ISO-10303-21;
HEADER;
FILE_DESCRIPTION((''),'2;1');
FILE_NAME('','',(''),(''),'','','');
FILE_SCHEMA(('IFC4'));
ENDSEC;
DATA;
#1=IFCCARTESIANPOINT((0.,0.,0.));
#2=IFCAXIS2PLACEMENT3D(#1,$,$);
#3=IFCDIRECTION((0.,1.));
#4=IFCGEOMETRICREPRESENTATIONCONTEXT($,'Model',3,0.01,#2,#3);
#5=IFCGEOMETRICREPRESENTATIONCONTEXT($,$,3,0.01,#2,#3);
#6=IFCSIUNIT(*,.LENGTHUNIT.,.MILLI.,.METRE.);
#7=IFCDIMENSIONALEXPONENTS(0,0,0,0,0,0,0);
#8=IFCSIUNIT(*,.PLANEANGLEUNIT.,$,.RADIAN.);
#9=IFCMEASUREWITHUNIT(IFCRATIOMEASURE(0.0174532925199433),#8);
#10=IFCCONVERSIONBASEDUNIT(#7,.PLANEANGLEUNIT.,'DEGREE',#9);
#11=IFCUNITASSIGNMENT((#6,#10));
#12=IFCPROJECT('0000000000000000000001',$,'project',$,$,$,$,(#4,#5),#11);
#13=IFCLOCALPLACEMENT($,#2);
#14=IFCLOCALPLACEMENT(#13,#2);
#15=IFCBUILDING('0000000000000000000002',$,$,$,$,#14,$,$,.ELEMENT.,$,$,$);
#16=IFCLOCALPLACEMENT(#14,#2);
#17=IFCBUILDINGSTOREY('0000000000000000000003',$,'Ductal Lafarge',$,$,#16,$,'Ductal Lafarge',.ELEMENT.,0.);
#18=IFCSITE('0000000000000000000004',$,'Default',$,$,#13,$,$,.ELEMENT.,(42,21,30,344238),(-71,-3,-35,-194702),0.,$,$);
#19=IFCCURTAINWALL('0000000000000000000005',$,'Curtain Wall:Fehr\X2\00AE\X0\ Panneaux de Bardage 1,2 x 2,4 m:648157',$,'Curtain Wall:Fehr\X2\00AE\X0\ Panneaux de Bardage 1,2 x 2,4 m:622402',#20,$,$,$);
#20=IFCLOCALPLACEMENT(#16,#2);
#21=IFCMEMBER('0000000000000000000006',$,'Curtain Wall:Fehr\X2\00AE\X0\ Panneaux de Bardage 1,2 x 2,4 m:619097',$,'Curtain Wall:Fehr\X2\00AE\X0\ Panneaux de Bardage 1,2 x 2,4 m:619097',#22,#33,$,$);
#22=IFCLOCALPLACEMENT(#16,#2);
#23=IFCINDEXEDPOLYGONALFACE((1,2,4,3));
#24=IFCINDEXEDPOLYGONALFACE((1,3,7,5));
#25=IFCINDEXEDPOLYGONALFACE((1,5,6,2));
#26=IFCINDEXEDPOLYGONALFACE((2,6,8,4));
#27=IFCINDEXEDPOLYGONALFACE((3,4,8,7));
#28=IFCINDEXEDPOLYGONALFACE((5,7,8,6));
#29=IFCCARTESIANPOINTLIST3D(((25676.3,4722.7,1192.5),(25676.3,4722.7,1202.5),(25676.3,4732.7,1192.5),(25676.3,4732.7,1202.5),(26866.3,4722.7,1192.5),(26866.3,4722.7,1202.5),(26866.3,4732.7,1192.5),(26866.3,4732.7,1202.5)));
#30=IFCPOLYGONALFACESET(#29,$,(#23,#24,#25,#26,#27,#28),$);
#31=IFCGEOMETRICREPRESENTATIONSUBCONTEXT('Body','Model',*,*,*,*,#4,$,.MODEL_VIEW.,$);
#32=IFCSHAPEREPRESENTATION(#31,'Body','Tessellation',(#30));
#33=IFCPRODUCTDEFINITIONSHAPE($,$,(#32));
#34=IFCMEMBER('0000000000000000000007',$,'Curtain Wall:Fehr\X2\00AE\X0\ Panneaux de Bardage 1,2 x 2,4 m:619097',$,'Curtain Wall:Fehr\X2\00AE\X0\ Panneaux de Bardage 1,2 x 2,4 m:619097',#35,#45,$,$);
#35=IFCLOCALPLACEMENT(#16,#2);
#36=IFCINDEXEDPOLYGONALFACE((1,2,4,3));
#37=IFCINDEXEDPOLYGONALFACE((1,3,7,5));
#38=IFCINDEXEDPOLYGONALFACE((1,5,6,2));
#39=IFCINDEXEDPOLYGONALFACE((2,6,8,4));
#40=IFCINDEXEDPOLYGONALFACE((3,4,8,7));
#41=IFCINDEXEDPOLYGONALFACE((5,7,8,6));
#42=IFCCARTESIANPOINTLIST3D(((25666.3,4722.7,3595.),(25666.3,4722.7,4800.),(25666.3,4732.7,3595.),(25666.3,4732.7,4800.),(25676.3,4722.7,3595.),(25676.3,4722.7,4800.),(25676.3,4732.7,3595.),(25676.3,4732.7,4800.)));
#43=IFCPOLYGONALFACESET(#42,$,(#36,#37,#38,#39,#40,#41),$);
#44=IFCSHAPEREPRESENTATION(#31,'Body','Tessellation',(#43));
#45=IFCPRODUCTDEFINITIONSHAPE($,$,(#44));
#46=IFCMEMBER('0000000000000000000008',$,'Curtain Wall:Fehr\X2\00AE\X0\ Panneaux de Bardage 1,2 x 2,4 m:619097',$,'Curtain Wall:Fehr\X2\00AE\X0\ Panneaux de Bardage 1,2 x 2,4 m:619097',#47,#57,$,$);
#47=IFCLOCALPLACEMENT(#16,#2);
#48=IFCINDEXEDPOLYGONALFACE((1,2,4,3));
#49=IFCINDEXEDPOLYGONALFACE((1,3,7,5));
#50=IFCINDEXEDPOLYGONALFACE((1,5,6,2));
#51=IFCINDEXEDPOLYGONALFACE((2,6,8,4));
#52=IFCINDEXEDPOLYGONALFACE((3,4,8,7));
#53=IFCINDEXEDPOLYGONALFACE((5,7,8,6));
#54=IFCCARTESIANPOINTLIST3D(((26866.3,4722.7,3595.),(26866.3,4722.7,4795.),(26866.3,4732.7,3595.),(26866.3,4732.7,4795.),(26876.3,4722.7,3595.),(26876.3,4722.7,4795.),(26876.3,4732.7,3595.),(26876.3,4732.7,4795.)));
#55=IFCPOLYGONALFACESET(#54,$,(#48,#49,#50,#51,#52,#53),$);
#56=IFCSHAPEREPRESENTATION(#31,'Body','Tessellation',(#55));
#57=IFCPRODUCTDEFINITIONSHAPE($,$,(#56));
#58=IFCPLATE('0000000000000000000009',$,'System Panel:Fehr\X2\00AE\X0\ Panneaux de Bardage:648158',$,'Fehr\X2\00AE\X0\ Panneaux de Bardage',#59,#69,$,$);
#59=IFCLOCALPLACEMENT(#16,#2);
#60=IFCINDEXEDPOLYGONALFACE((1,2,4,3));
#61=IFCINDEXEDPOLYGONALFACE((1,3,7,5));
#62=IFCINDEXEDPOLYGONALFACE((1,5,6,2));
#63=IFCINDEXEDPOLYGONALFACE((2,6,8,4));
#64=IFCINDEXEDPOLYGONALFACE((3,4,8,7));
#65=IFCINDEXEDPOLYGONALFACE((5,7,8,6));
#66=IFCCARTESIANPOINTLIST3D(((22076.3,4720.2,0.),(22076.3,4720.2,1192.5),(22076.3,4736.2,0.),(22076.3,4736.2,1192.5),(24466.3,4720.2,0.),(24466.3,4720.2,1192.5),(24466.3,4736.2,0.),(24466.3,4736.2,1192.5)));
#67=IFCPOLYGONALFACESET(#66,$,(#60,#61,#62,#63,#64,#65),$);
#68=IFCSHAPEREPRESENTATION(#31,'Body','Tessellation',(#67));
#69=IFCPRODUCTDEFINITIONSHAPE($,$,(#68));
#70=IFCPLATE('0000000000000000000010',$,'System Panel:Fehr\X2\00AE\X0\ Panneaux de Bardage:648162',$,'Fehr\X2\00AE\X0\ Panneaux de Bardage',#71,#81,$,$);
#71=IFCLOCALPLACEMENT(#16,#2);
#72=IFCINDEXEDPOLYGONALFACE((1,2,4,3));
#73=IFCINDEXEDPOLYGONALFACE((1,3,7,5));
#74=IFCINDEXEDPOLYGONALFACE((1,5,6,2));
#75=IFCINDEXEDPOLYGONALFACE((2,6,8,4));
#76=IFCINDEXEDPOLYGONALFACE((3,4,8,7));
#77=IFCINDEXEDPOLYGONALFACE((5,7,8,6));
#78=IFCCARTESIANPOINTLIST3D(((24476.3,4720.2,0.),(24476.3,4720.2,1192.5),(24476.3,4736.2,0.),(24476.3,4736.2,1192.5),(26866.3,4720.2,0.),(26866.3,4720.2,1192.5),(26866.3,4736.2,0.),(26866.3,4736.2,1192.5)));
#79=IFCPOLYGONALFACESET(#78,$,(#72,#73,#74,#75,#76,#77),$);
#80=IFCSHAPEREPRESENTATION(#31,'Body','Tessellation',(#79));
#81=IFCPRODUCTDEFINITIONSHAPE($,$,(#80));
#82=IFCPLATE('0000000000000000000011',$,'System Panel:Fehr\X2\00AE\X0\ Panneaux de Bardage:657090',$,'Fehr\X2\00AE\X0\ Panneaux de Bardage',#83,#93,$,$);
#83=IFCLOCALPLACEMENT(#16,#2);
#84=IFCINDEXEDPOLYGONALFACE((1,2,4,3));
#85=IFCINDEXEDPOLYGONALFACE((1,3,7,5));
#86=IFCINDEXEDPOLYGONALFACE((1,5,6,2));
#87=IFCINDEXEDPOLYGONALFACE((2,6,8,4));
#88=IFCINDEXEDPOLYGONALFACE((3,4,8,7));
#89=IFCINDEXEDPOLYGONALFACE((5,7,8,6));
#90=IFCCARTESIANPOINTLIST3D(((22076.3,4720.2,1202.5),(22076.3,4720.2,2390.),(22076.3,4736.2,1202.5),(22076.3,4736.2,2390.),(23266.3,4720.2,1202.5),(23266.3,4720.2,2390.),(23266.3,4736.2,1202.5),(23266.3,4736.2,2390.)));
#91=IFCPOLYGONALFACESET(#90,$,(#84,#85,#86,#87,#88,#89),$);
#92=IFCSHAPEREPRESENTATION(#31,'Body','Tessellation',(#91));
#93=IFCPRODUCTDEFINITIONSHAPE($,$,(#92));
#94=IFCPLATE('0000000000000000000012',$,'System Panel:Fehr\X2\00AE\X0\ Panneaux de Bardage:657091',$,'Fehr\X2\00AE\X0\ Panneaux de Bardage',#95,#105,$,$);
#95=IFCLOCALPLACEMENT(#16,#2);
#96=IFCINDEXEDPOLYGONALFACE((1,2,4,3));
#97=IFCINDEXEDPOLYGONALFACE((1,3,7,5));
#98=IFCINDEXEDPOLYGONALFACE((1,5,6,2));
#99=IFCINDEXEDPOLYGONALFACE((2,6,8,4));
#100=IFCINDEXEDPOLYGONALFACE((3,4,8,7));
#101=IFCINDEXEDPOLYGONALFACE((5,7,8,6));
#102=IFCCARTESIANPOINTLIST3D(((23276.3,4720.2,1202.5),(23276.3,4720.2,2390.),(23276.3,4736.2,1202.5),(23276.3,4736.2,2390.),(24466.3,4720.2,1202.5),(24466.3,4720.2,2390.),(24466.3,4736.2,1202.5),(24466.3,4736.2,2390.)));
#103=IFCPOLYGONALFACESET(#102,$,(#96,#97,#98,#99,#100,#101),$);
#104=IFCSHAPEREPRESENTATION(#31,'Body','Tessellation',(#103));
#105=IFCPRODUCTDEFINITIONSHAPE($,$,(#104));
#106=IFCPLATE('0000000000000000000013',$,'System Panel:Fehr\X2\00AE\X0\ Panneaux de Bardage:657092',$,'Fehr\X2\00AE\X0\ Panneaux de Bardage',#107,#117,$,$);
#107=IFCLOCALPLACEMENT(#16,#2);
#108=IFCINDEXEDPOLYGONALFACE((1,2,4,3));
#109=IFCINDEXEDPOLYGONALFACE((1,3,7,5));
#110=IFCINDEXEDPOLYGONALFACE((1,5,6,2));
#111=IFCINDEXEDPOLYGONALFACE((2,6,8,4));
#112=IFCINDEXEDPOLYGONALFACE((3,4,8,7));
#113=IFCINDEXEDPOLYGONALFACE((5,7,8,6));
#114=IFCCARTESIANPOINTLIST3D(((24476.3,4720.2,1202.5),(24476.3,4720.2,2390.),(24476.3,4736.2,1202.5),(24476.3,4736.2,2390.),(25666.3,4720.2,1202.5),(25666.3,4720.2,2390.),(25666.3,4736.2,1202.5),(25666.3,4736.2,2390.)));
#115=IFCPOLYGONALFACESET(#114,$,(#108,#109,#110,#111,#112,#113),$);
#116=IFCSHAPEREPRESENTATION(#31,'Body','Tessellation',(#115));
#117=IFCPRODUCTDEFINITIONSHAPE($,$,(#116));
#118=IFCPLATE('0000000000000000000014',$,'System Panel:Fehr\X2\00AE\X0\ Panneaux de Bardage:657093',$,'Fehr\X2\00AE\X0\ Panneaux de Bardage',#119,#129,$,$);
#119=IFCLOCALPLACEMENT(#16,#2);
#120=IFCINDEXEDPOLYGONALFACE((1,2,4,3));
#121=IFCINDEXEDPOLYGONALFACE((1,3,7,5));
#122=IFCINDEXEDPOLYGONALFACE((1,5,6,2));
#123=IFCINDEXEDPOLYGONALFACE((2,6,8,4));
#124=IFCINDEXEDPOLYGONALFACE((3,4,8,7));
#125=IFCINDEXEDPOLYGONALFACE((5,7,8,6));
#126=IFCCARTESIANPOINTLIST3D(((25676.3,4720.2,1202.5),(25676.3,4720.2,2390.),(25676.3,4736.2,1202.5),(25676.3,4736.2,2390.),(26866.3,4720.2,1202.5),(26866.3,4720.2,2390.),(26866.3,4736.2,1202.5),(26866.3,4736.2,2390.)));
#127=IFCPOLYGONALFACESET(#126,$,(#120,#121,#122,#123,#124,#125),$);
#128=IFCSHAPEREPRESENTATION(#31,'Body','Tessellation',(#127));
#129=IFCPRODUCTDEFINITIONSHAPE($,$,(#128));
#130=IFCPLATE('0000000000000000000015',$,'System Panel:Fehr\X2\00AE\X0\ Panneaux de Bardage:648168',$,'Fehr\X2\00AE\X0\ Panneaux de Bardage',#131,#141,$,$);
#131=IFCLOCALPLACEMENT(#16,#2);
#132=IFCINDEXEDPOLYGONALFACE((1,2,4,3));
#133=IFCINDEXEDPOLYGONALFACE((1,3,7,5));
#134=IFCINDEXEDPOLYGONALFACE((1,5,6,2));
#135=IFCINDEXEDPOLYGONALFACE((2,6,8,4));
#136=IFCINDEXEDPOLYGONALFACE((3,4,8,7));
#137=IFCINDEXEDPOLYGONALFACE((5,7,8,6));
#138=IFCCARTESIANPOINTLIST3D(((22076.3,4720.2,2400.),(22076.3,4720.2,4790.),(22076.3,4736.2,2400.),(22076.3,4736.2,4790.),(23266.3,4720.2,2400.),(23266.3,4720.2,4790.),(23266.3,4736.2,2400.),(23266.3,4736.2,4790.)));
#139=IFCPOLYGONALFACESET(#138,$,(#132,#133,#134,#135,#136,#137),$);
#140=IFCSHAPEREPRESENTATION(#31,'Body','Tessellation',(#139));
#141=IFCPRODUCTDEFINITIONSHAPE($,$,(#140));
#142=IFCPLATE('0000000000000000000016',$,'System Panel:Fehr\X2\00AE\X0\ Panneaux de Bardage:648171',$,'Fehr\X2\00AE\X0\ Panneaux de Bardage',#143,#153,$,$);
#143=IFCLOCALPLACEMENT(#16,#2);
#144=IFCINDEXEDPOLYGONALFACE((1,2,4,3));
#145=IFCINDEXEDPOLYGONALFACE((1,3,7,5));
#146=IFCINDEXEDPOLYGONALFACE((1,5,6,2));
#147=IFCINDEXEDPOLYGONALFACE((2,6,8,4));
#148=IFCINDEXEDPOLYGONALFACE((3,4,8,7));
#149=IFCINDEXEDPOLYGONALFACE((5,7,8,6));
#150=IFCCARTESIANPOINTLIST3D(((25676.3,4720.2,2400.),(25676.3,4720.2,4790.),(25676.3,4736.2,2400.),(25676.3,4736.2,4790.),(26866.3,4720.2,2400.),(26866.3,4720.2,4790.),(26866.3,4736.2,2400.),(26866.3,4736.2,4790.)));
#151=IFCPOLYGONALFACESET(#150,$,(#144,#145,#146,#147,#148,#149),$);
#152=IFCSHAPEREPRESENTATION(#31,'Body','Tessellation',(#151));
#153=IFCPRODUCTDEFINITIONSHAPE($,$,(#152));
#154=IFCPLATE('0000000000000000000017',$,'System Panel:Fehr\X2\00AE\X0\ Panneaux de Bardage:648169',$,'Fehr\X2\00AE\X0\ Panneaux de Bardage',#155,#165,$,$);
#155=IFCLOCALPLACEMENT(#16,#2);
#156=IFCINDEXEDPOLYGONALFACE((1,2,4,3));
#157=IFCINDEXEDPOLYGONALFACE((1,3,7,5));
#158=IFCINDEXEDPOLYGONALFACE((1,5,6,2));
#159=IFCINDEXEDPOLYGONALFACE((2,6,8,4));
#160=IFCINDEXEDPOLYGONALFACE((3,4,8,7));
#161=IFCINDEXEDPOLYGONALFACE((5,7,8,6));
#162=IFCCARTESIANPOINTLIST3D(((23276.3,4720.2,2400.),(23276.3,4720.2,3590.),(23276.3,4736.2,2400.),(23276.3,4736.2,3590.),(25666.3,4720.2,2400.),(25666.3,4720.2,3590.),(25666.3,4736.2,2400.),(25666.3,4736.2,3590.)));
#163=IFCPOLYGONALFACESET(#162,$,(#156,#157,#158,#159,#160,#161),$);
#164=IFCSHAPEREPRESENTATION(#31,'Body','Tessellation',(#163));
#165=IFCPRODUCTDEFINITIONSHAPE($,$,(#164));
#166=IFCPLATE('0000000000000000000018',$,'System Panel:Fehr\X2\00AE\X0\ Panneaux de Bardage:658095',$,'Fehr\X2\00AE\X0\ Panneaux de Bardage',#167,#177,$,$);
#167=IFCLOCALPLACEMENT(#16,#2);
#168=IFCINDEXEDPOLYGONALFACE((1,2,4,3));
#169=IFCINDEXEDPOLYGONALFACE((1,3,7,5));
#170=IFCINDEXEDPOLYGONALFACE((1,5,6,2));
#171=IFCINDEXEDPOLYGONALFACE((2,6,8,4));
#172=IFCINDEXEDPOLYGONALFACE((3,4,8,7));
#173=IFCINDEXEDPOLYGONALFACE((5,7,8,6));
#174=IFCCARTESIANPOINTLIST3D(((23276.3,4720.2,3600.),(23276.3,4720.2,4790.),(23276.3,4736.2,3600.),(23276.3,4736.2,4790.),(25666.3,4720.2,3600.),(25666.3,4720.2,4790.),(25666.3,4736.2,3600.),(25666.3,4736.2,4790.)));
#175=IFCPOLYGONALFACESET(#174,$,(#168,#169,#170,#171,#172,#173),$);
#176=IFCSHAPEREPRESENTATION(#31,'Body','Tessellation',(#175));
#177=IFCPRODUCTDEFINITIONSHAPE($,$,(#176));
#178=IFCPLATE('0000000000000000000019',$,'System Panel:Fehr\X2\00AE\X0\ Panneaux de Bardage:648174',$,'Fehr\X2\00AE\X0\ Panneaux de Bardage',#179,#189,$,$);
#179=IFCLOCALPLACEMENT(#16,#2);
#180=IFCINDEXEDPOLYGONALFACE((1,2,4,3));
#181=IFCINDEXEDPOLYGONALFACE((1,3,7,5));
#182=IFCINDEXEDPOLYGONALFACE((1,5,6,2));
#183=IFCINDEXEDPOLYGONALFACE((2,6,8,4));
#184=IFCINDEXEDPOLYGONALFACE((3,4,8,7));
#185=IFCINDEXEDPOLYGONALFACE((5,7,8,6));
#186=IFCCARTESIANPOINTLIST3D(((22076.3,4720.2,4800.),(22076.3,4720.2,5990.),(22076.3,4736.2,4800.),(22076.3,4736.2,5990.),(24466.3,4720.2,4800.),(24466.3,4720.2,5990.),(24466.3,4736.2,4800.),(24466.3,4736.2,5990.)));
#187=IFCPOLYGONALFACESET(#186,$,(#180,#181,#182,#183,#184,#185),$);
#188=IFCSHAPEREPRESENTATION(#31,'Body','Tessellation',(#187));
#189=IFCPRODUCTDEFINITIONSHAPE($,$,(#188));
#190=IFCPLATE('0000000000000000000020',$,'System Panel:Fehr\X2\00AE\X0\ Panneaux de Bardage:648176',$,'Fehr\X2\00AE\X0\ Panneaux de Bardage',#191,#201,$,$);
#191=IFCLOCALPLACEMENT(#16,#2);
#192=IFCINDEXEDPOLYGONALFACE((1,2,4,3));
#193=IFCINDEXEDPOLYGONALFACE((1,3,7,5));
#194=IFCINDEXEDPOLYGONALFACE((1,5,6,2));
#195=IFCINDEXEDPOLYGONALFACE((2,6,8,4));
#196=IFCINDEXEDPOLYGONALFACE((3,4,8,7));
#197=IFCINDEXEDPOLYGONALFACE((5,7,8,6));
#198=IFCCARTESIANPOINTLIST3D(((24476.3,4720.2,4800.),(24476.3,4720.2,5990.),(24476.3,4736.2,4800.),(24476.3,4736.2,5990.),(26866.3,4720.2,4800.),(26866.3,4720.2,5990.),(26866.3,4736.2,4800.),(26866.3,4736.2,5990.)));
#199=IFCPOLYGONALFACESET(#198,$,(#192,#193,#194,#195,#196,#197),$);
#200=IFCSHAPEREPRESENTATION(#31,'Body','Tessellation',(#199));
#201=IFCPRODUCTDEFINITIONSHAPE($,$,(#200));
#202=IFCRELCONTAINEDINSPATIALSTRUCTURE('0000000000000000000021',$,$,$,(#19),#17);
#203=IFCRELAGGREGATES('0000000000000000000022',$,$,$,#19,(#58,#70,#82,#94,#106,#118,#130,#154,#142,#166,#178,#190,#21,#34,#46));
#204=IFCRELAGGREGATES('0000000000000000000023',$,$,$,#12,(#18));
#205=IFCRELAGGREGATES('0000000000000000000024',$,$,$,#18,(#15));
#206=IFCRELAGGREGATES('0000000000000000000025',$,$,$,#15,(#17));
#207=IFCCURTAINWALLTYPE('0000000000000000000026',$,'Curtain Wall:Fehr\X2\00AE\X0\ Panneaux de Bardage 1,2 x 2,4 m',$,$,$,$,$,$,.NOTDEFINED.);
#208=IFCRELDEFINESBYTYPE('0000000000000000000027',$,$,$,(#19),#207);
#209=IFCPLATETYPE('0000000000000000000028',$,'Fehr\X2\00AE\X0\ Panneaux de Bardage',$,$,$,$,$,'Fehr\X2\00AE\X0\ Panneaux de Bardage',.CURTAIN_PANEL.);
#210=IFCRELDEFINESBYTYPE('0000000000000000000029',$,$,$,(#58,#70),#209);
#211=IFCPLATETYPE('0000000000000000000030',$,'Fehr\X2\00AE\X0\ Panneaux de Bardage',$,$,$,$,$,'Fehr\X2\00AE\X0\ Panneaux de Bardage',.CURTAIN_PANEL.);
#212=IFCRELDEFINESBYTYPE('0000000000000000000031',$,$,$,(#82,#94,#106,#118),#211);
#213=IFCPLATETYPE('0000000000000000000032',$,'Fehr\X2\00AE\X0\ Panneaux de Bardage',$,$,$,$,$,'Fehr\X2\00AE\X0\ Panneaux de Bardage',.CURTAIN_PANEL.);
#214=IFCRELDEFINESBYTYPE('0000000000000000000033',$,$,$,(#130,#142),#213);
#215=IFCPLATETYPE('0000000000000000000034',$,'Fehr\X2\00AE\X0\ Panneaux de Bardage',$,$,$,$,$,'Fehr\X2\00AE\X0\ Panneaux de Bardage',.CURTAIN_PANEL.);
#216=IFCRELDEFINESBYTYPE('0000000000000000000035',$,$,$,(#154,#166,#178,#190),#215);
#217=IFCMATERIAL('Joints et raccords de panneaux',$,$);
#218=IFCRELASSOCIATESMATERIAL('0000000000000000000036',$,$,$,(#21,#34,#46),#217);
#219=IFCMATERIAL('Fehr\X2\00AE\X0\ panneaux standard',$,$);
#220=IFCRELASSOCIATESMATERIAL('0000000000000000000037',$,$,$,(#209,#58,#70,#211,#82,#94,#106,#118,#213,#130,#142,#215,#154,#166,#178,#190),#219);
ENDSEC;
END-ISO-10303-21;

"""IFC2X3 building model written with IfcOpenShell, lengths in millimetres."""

from ifc_helpers import new_model, entity, si_unit, converted_unit, direction, frame, frame_2d, origin, origin_2d_with_axis, place, context, subcontext, project, spatial, rectangle, extrude, source, transform, mapped, material, type_object, type_shapes, element, aggregate, save


model = new_model("IFC2X3")

# Units and contexts
model_context = context("Model", 3, precision=0.01, world=origin(), true_north=direction((0.0, 1.0)))
context_of_model = context(None, 3, precision=0.01, world=origin(), true_north=direction((0.0, 1.0)))
body_context = subcontext(model_context, "Body", "Model", "MODEL_VIEW")
ifc_project = project(units=[si_unit("LENGTHUNIT", "METRE", prefix="MILLI"), converted_unit("PLANEANGLEUNIT", "DEGREE", entity("IfcRatioMeasure", 0.0174532925199433), si_unit("PLANEANGLEUNIT", "RADIAN"), dimensions=[0, 0, 0, 0, 0, 0, 0])], contexts=[model_context, context_of_model])

# Site, building, storey
site_placement = place(None, origin())
site = spatial("IfcSite", under=ifc_project, at=site_placement, Name="Default", CompositionType="ELEMENT", RefLatitude=(42, 21, 30, 344238), RefLongitude=(-71, -3, -35, -194702), RefElevation=0.0)
building_placement = place(site_placement, origin())
building = spatial("IfcBuilding", under=site, at=building_placement, CompositionType="ELEMENT")
storey_placement = place(building_placement, origin())
storey = spatial("IfcBuildingStorey", under=building, at=storey_placement, Name="Ductal Lafarge", LongName="Ductal Lafarge", CompositionType="ELEMENT", Elevation=0.0)

# Curtain wall, members, plates
curtain_wall_type = type_object("IfcCurtainWallType", Name="Curtain Wall:Fehr® Panneaux de Bardage 1,2 x 2,4 m", PredefinedType="NOTDEFINED")
curtain_wall_placement = place(storey_placement, origin())
curtain_wall = element("IfcCurtainWall", 1, at=curtain_wall_placement, inside=storey, type_object=curtain_wall_type, Name="Curtain Wall:Fehr® Panneaux de Bardage 1,2 x 2,4 m:648157", ObjectType="Curtain Wall:Fehr® Panneaux de Bardage 1,2 x 2,4 m:622402")
ifc_material_1 = material(Name="Joints et raccords de panneaux")
member_1_placement = place(curtain_wall_placement, frame((25676.3, 4722.7, 1192.5)))
member_1 = element("IfcMember", 2, at=member_1_placement, material=ifc_material_1, Name="Curtain Wall:Fehr® Panneaux de Bardage 1,2 x 2,4 m:619097", ObjectType="Curtain Wall:Fehr® Panneaux de Bardage 1,2 x 2,4 m:619097", context=body_context, shape_type="SweptSolid", body=[
    extrude(rectangle(XDim=1190.0, YDim=10.0, at=frame_2d((0.0, 0.0), x_axis=(1.0, 0.0))), frame((595.0, 5.0, 0.0), z_axis=(0.0, 0.0, 1.0), x_axis=(-1.0, 0.0, 0.0)), (0.0, 0.0, 1.0), 10.0),
])
member_2_placement = place(curtain_wall_placement, frame((25666.3, 4722.7, 3595.0)))
member_2 = element("IfcMember", 3, at=member_2_placement, material=ifc_material_1, Name="Curtain Wall:Fehr® Panneaux de Bardage 1,2 x 2,4 m:619097", ObjectType="Curtain Wall:Fehr® Panneaux de Bardage 1,2 x 2,4 m:619097", context=body_context, shape_type="SweptSolid", body=[
    extrude(rectangle(XDim=10.0, YDim=10.0, at=origin_2d_with_axis()), frame((5.0, 5.0, 0.0), z_axis=(0.0, 0.0, 1.0), x_axis=(0.0, 1.0, 0.0)), (0.0, 0.0, 1.0), 1205.0),
])
member_3_placement = place(curtain_wall_placement, frame((26866.3, 4722.7, 3595.0)))
member_3 = element("IfcMember", 4, at=member_3_placement, material=ifc_material_1, Name="Curtain Wall:Fehr® Panneaux de Bardage 1,2 x 2,4 m:619097", ObjectType="Curtain Wall:Fehr® Panneaux de Bardage 1,2 x 2,4 m:619097", context=body_context, shape_type="SweptSolid", body=[
    extrude(rectangle(XDim=10.0, YDim=10.0, at=frame_2d((0.0, 0.0), x_axis=(1.0, 0.0))), frame((5.0, 5.0, 0.0), z_axis=(0.0, 0.0, 1.0), x_axis=(0.0, 1.0, 0.0)), (0.0, 0.0, 1.0), 1200.0),
])
ifc_material_2 = material(Name="Fehr® panneaux standard")
plate_type_1 = type_object("IfcPlateType", Name="Fehr® Panneaux de Bardage", ElementType="Fehr® Panneaux de Bardage", PredefinedType="CURTAIN_PANEL", material=ifc_material_2)
shared_shape_1 = source(origin(), body_context, "Body", "SweptSolid", [
    extrude(rectangle(XDim=1192.5, YDim=2390.0, at=frame_2d((0.0, 0.0), x_axis=(1.0, 0.0))), frame((0.0, -8.0, 596.2), z_axis=(0.0, 1.0, 0.0), x_axis=(0.0, 0.0, 1.0)), (0.0, 0.0, 1.0), 16.0),
])
type_shapes(plate_type_1, [shared_shape_1])
plate_1_placement = place(curtain_wall_placement, frame((23271.3, 4728.2, 0.0)))
plate_1 = element("IfcPlate", 5, at=plate_1_placement, type_object=plate_type_1, material=ifc_material_2, Name="System Panel:Fehr® Panneaux de Bardage:648158", ObjectType="Fehr® Panneaux de Bardage", context=body_context, shape_type="MappedRepresentation", body=[
    mapped(shared_shape_1, transform((0.0, 0.0, 0.0), scale=1.0)),
])
plate_2_placement = place(curtain_wall_placement, frame((25671.3, 4728.2, 0.0)))
plate_2 = element("IfcPlate", 6, at=plate_2_placement, type_object=plate_type_1, material=ifc_material_2, Name="System Panel:Fehr® Panneaux de Bardage:648162", ObjectType="Fehr® Panneaux de Bardage", context=body_context, shape_type="MappedRepresentation", body=[
    mapped(shared_shape_1, transform((0.0, 0.0, 0.0), scale=1.0)),
])
plate_type_2 = type_object("IfcPlateType", Name="Fehr® Panneaux de Bardage", ElementType="Fehr® Panneaux de Bardage", PredefinedType="CURTAIN_PANEL", material=ifc_material_2)
shared_shape_2 = source(origin(), body_context, "Body", "SweptSolid", [
    extrude(rectangle(XDim=16.0, YDim=1190.0, at=origin_2d_with_axis()), frame((0.0, 0.0, 0.0), z_axis=(0.0, 0.0, 1.0), x_axis=(0.0, 1.0, 0.0)), (0.0, 0.0, 1.0), 1187.5),
])
type_shapes(plate_type_2, [shared_shape_2])
plate_3_placement = place(curtain_wall_placement, frame((22671.3, 4728.2, 1202.5)))
plate_3 = element("IfcPlate", 7, at=plate_3_placement, type_object=plate_type_2, material=ifc_material_2, Name="System Panel:Fehr® Panneaux de Bardage:657090", ObjectType="Fehr® Panneaux de Bardage", context=body_context, shape_type="MappedRepresentation", body=[
    mapped(shared_shape_2, transform((0.0, 0.0, 0.0), scale=1.0)),
])
plate_4_placement = place(curtain_wall_placement, frame((23871.3, 4728.2, 1202.5)))
plate_4 = element("IfcPlate", 8, at=plate_4_placement, type_object=plate_type_2, material=ifc_material_2, Name="System Panel:Fehr® Panneaux de Bardage:657091", ObjectType="Fehr® Panneaux de Bardage", context=body_context, shape_type="MappedRepresentation", body=[
    mapped(shared_shape_2, transform((0.0, 0.0, 0.0), scale=1.0)),
])
plate_5_placement = place(curtain_wall_placement, frame((25071.3, 4728.2, 1202.5)))
plate_5 = element("IfcPlate", 9, at=plate_5_placement, type_object=plate_type_2, material=ifc_material_2, Name="System Panel:Fehr® Panneaux de Bardage:657092", ObjectType="Fehr® Panneaux de Bardage", context=body_context, shape_type="MappedRepresentation", body=[
    mapped(shared_shape_2, transform((0.0, 0.0, 0.0), scale=1.0)),
])
plate_6_placement = place(curtain_wall_placement, frame((26271.3, 4728.2, 1202.5)))
plate_6 = element("IfcPlate", 10, at=plate_6_placement, type_object=plate_type_2, material=ifc_material_2, Name="System Panel:Fehr® Panneaux de Bardage:657093", ObjectType="Fehr® Panneaux de Bardage", context=body_context, shape_type="MappedRepresentation", body=[
    mapped(shared_shape_2, transform((0.0, 0.0, 0.0), scale=1.0)),
])
plate_type_3 = type_object("IfcPlateType", Name="Fehr® Panneaux de Bardage", ElementType="Fehr® Panneaux de Bardage", PredefinedType="CURTAIN_PANEL", material=ifc_material_2)
shared_shape_3 = source(origin(), body_context, "Body", "SweptSolid", [
    extrude(rectangle(XDim=2390.0, YDim=1190.0, at=origin_2d_with_axis()), frame((0.0, -8.0, 1195.0), z_axis=(0.0, 1.0, 0.0), x_axis=(0.0, 0.0, 1.0)), (0.0, 0.0, 1.0), 16.0),
])
type_shapes(plate_type_3, [shared_shape_3])
plate_7_placement = place(curtain_wall_placement, frame((22671.3, 4728.2, 2400.0)))
plate_7 = element("IfcPlate", 11, at=plate_7_placement, type_object=plate_type_3, material=ifc_material_2, Name="System Panel:Fehr® Panneaux de Bardage:648168", ObjectType="Fehr® Panneaux de Bardage", context=body_context, shape_type="MappedRepresentation", body=[
    mapped(shared_shape_3, transform((0.0, 0.0, 0.0), scale=1.0)),
])
plate_8_placement = place(curtain_wall_placement, frame((26271.3, 4728.2, 2400.0)))
plate_8 = element("IfcPlate", 12, at=plate_8_placement, type_object=plate_type_3, material=ifc_material_2, Name="System Panel:Fehr® Panneaux de Bardage:648171", ObjectType="Fehr® Panneaux de Bardage", context=body_context, shape_type="MappedRepresentation", body=[
    mapped(shared_shape_3, transform((0.0, 0.0, 0.0), scale=1.0)),
])
plate_type_4 = type_object("IfcPlateType", Name="Fehr® Panneaux de Bardage", ElementType="Fehr® Panneaux de Bardage", PredefinedType="CURTAIN_PANEL", material=ifc_material_2)
shared_shape_4 = source(origin(), body_context, "Body", "SweptSolid", [
    extrude(rectangle(XDim=1190.0, YDim=2390.0, at=origin_2d_with_axis()), frame((0.0, -8.0, 595.0), z_axis=(0.0, 1.0, 0.0), x_axis=(0.0, 0.0, 1.0)), (0.0, 0.0, 1.0), 16.0),
])
type_shapes(plate_type_4, [shared_shape_4])
plate_9_placement = place(curtain_wall_placement, frame((24471.3, 4728.2, 2400.0)))
plate_9 = element("IfcPlate", 13, at=plate_9_placement, type_object=plate_type_4, material=ifc_material_2, Name="System Panel:Fehr® Panneaux de Bardage:648169", ObjectType="Fehr® Panneaux de Bardage", context=body_context, shape_type="MappedRepresentation", body=[
    mapped(shared_shape_4, transform((0.0, 0.0, 0.0), scale=1.0)),
])
plate_10_placement = place(curtain_wall_placement, frame((24471.3, 4728.2, 3600.0)))
plate_10 = element("IfcPlate", 14, at=plate_10_placement, type_object=plate_type_4, material=ifc_material_2, Name="System Panel:Fehr® Panneaux de Bardage:658095", ObjectType="Fehr® Panneaux de Bardage", context=body_context, shape_type="MappedRepresentation", body=[
    mapped(shared_shape_4, transform((0.0, 0.0, 0.0), scale=1.0)),
])
plate_11_placement = place(curtain_wall_placement, frame((23271.3, 4728.2, 4800.0)))
plate_11 = element("IfcPlate", 15, at=plate_11_placement, type_object=plate_type_4, material=ifc_material_2, Name="System Panel:Fehr® Panneaux de Bardage:648174", ObjectType="Fehr® Panneaux de Bardage", context=body_context, shape_type="MappedRepresentation", body=[
    mapped(shared_shape_4, transform((0.0, 0.0, 0.0), scale=1.0)),
])
plate_12_placement = place(curtain_wall_placement, frame((25671.3, 4728.2, 4800.0)))
plate_12 = element("IfcPlate", 16, at=plate_12_placement, type_object=plate_type_4, material=ifc_material_2, Name="System Panel:Fehr® Panneaux de Bardage:648176", ObjectType="Fehr® Panneaux de Bardage", context=body_context, shape_type="MappedRepresentation", body=[
    mapped(shared_shape_4, transform((0.0, 0.0, 0.0), scale=1.0)),
])
aggregate(curtain_wall, [plate_1, plate_2, plate_3, plate_4, plate_5, plate_6, plate_7, plate_9, plate_8, plate_10, plate_11, plate_12, member_1, member_2, member_3])

save(model, "model.ifc")
